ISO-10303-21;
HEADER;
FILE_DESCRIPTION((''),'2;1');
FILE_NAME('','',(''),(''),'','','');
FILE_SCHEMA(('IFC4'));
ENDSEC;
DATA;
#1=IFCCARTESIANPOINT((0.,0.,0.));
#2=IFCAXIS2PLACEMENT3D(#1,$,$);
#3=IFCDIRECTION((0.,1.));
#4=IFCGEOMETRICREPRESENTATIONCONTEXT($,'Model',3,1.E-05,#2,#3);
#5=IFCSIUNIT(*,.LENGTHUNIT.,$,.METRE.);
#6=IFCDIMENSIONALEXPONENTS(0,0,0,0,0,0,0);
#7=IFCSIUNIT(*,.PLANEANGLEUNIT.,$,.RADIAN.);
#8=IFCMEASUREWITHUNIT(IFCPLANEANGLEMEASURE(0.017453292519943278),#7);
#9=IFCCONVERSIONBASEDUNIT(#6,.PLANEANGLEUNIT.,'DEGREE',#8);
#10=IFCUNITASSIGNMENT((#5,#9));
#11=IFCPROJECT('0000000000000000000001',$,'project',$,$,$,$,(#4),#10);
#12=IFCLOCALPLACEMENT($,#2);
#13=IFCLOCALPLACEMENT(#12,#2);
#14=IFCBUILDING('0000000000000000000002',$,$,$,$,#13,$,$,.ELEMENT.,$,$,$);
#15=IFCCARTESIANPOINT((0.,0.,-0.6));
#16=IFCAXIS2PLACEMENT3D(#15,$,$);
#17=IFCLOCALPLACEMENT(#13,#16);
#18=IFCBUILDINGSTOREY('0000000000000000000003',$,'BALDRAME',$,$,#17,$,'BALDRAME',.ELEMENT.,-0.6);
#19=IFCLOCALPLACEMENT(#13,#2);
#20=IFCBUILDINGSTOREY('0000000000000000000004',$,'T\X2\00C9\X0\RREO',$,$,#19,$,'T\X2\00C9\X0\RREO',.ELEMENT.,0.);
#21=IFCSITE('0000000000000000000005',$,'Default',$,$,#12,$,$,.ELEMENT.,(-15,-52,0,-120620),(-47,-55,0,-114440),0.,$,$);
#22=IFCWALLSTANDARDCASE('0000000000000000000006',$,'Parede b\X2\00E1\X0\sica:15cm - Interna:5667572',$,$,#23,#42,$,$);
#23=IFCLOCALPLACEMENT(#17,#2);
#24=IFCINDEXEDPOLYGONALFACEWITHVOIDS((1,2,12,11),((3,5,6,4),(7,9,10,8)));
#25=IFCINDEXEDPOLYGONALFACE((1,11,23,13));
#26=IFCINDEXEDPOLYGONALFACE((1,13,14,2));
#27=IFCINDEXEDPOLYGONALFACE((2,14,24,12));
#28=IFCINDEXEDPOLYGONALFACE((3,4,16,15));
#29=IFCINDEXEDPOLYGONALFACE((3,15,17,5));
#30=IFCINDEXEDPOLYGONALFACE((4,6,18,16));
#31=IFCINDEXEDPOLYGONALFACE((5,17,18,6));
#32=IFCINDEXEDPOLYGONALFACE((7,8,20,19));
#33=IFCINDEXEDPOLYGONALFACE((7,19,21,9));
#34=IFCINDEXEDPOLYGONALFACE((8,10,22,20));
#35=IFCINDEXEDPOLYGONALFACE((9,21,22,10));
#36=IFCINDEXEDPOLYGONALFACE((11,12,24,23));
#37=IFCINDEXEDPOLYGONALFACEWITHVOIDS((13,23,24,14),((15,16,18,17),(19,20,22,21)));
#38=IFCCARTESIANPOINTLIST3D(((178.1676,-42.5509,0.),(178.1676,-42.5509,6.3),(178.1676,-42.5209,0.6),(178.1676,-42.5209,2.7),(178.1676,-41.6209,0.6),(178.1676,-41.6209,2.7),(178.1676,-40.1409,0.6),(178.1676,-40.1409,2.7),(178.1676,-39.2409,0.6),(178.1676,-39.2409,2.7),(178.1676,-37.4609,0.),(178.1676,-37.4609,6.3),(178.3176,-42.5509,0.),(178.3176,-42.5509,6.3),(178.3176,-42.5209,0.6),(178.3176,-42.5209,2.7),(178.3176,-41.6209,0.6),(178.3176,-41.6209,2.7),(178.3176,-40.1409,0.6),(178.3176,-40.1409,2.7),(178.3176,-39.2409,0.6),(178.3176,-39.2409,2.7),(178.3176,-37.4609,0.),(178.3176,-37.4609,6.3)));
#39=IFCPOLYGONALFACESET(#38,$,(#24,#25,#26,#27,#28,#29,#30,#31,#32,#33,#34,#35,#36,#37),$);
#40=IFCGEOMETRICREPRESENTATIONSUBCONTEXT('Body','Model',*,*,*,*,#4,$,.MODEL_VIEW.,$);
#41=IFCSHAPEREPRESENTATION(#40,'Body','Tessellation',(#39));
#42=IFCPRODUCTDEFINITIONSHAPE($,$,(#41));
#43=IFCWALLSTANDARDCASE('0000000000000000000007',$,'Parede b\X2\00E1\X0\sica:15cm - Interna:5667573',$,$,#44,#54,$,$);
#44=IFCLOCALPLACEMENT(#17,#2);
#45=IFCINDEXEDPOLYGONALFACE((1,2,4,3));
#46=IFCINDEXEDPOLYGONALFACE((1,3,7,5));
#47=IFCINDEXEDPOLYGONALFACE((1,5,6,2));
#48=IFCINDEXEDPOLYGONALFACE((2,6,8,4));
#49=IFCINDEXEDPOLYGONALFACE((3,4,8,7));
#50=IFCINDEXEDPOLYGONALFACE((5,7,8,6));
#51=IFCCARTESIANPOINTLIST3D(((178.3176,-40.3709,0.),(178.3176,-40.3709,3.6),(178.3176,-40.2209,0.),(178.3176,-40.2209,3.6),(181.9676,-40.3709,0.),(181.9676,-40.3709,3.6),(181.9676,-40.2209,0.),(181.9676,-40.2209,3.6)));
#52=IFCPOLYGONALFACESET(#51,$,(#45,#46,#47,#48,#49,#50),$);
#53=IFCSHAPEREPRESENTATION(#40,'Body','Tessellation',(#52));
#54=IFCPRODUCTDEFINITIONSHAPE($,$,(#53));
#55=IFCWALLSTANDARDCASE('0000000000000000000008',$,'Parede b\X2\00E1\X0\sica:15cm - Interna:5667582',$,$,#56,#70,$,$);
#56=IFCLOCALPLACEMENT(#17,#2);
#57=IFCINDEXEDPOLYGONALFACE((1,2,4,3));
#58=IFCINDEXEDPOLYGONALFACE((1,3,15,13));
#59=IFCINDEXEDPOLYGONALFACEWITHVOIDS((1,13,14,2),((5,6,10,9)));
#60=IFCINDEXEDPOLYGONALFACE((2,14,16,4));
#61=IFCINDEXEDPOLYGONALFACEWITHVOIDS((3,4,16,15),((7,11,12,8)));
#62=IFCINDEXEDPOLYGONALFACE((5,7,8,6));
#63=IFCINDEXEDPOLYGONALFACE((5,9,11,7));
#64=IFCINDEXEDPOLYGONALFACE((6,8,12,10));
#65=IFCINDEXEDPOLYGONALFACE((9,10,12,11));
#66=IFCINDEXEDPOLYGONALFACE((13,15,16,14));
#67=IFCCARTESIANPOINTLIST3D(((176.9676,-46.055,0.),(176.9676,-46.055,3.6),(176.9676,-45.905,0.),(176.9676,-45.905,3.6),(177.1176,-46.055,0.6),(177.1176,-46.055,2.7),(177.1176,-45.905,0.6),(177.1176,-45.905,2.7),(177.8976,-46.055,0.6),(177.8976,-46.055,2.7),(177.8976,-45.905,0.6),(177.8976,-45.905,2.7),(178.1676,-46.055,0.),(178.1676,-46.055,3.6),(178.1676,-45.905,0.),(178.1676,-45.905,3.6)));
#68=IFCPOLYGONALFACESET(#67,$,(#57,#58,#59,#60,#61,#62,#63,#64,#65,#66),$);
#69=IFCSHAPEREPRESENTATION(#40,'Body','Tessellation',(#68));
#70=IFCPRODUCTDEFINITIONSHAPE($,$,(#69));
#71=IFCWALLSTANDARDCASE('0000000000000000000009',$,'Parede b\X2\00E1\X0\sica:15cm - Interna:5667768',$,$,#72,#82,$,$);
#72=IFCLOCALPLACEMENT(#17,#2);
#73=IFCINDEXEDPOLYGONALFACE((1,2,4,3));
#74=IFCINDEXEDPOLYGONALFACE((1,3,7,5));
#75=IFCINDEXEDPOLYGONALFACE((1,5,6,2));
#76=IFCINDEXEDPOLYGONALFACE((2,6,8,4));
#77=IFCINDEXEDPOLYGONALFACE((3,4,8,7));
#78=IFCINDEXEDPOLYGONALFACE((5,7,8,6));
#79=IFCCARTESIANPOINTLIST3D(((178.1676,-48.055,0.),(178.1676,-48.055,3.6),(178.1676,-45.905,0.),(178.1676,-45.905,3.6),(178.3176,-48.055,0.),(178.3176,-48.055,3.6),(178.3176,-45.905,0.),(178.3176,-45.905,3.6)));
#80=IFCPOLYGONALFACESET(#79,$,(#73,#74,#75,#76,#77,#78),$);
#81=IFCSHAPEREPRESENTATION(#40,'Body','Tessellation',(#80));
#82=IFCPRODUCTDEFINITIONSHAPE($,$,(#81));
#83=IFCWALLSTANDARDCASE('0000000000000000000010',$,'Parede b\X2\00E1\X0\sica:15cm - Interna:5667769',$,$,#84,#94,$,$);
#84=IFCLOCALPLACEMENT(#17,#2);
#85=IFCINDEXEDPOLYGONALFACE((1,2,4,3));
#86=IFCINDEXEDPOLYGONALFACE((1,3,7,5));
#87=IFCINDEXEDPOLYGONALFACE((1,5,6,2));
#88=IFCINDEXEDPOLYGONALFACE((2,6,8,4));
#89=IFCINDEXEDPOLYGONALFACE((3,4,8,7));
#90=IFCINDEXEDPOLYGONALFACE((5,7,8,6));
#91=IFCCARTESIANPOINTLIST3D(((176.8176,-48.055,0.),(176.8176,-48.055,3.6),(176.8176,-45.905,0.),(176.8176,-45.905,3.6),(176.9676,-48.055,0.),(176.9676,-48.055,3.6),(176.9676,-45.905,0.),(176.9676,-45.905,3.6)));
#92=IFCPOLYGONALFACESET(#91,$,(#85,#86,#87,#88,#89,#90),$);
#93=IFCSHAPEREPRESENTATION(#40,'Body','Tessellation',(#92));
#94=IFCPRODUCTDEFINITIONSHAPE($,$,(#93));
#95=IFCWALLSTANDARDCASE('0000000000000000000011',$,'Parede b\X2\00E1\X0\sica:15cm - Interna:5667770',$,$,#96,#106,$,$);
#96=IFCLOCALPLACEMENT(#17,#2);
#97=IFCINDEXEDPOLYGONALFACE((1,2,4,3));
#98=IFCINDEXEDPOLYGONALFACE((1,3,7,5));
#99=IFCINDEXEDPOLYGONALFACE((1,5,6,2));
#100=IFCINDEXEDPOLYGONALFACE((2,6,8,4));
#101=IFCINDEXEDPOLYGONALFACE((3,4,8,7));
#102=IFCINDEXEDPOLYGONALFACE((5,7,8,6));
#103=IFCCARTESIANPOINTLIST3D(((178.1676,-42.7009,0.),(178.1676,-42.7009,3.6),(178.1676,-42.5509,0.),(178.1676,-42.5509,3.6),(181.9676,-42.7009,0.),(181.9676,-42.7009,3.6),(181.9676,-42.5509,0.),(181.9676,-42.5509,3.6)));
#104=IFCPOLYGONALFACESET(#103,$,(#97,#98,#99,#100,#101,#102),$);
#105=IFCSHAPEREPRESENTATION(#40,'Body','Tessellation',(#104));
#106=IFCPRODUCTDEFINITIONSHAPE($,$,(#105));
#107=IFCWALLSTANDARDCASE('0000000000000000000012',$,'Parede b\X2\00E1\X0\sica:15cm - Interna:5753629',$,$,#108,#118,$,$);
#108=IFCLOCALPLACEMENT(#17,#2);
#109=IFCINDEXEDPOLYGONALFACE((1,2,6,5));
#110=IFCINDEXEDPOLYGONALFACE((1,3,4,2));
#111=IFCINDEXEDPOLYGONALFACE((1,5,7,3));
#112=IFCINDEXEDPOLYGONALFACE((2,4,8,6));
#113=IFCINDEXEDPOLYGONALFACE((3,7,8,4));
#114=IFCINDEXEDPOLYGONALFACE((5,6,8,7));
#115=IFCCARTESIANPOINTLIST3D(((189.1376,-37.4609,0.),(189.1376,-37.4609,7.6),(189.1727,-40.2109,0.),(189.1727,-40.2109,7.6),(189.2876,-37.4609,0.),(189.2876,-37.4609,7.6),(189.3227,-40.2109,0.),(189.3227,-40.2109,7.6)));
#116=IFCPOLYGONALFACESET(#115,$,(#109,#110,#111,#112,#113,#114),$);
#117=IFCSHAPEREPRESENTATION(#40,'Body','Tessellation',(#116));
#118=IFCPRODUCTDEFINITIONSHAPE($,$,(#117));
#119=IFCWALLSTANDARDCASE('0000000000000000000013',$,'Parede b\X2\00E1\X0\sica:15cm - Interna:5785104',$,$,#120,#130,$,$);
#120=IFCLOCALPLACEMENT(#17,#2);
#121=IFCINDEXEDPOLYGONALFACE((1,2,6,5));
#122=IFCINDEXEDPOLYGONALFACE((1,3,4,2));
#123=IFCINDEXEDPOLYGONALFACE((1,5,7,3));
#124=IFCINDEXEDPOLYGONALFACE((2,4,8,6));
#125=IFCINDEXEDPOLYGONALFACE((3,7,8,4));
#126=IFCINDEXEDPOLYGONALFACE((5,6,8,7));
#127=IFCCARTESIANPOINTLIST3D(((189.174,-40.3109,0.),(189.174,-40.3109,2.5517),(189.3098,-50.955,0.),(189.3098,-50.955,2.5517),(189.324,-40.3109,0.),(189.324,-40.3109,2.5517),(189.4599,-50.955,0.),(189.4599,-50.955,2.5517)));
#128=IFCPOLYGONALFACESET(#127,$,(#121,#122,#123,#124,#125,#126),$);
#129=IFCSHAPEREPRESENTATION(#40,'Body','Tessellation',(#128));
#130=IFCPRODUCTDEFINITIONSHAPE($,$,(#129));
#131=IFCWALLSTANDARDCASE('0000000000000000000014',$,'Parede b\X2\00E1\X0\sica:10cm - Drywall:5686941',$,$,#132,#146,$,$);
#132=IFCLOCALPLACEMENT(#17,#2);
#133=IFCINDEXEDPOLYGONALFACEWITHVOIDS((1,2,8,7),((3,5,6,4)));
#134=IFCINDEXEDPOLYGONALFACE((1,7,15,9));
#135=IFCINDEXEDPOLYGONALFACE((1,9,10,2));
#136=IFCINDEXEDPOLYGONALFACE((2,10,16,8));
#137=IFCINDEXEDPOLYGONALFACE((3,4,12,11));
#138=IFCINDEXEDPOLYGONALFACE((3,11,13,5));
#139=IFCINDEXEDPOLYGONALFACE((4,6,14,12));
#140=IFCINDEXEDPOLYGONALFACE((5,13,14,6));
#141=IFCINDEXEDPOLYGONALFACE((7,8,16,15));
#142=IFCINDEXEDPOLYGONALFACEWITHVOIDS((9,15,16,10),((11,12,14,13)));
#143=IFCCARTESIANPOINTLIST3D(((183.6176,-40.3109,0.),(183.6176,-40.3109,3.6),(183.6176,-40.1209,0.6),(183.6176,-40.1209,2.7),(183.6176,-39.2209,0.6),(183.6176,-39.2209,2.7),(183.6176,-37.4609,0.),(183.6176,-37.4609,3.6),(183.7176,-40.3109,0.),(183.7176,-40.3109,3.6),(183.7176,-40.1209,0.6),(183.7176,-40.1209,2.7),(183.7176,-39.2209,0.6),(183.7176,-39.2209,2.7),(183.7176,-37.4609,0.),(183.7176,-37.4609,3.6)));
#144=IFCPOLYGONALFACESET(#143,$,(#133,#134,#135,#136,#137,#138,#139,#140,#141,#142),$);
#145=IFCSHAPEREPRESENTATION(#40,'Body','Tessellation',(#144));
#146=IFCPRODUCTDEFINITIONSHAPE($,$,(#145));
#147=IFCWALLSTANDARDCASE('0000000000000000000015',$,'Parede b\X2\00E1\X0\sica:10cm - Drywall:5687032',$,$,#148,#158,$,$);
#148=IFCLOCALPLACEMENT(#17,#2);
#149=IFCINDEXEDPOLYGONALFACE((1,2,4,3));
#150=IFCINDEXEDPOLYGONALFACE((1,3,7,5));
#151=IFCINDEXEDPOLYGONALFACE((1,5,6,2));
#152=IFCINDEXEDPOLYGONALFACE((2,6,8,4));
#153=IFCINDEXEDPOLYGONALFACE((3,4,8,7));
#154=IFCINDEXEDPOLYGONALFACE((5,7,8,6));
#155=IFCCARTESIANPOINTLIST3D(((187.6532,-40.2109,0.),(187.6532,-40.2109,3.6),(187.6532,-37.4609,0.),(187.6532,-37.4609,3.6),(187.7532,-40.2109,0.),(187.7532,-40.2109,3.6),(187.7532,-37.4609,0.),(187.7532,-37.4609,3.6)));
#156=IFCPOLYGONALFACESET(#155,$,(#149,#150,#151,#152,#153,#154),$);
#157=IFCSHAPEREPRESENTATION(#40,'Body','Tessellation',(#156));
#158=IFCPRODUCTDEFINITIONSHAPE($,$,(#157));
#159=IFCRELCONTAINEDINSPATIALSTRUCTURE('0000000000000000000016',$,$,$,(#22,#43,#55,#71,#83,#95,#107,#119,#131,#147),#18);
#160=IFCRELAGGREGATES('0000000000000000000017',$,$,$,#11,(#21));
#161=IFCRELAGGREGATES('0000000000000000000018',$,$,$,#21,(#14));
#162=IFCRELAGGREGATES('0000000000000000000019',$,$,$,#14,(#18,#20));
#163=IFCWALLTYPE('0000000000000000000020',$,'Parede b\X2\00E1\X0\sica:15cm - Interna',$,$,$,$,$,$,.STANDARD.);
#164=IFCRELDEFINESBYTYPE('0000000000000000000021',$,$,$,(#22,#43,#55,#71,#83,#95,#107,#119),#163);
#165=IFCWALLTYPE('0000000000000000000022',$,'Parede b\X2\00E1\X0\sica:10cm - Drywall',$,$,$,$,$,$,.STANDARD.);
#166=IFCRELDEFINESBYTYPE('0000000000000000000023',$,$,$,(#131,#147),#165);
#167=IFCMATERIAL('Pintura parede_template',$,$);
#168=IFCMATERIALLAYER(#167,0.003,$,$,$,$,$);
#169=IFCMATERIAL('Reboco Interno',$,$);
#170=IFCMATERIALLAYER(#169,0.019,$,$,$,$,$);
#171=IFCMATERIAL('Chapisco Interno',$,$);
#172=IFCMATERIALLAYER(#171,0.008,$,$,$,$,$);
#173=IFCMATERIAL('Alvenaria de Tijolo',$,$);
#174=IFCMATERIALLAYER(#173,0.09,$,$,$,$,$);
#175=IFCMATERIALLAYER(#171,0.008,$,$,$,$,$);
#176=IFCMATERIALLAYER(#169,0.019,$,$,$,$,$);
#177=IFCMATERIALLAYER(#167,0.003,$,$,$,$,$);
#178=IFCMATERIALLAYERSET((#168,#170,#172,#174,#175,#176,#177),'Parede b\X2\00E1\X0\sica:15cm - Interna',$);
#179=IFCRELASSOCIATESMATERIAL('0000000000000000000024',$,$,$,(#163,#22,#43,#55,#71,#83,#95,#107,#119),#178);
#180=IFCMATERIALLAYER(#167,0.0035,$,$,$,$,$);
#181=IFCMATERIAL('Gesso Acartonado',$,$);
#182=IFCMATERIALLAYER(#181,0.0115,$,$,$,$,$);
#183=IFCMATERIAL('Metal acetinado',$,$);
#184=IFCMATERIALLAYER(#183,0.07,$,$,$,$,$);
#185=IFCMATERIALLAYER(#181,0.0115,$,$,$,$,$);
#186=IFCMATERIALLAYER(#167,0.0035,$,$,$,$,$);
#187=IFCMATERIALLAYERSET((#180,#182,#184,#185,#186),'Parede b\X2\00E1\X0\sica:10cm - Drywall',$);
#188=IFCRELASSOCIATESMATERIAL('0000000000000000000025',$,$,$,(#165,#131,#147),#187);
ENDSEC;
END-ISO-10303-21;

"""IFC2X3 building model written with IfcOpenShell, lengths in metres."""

from ifc_helpers import new_model, entity, si_unit, converted_unit, direction, frame, frame_2d, origin, place, context, subcontext, project, spatial, polyline, rectangle, outline, extrude, material, layer, layer_set, layer_usage, type_object, element, save


model = new_model("IFC2X3")

# Units and contexts
model_context = context("Model", 3, precision=1e-05, world=origin(), true_north=direction((0.0, 1.0)))
body_context = subcontext(model_context, "Body", "Model", "MODEL_VIEW")
ifc_project = project(units=[si_unit("LENGTHUNIT", "METRE"), converted_unit("PLANEANGLEUNIT", "DEGREE", entity("IfcPlaneAngleMeasure", 0.017453292519943278), si_unit("PLANEANGLEUNIT", "RADIAN"), dimensions=[0, 0, 0, 0, 0, 0, 0])], contexts=[model_context])

# Site, building, storey
site_placement = place(None, origin())
site = spatial("IfcSite", under=ifc_project, at=site_placement, Name="Default", CompositionType="ELEMENT", RefLatitude=(-15, -52, 0, -120620), RefLongitude=(-47, -55, 0, -114440), RefElevation=0.0)
building_placement = place(site_placement, origin())
building = spatial("IfcBuilding", under=site, at=building_placement, CompositionType="ELEMENT")
storey_1_placement = place(building_placement, frame((0.0, 0.0, -0.6)))
storey_1 = spatial("IfcBuildingStorey", under=building, at=storey_1_placement, Name="BALDRAME", LongName="BALDRAME", CompositionType="ELEMENT", Elevation=-0.6)

# Shared definitions
ifc_material_1 = material(Name="Pintura parede_template")
ifc_layer_1 = layer(ifc_material_1, 0.003)
ifc_material_2 = material(Name="Reboco Interno")
ifc_layer_2 = layer(ifc_material_2, 0.019)
ifc_material_3 = material(Name="Chapisco Interno")
ifc_layer_3 = layer(ifc_material_3, 0.008)
ifc_material_4 = material(Name="Alvenaria de Tijolo")
ifc_layer_4 = layer(ifc_material_4, 0.09)
ifc_layer_5 = layer(ifc_material_3, 0.008)
ifc_layer_6 = layer(ifc_material_2, 0.019)
ifc_layer_7 = layer(ifc_material_1, 0.003)
ifc_layer_set_1 = layer_set([ifc_layer_1, ifc_layer_2, ifc_layer_3, ifc_layer_4, ifc_layer_5, ifc_layer_6, ifc_layer_7], Name="Parede básica:15cm - Interna")
wall_type_1 = type_object("IfcWallType", Name="Parede básica:15cm - Interna", PredefinedType="STANDARD", material=ifc_layer_set_1)

# Shared definitions
storey_2_placement = place(building_placement, origin())
storey_2 = spatial("IfcBuildingStorey", under=building, at=storey_2_placement, Name="TÉRREO", LongName="TÉRREO", CompositionType="ELEMENT", Elevation=0.0)

# Shared definitions
ifc_material_5 = material(Name="Metal acetinado")

# Wall, openings
ifc_layer_usage_1 = layer_usage(ifc_layer_set_1, "AXIS2", "POSITIVE", -0.075)
wall_1_placement = place(storey_1_placement, frame((178.2426, -37.4609, 0.0), z_axis=(0.0, 0.0, 1.0), x_axis=(0.0, -1.0, 0.0)))
wall_1 = element("IfcWallStandardCase", 1, at=wall_1_placement, inside=storey_1, type_object=wall_type_1, material=ifc_layer_usage_1, Name="Parede básica:15cm - Interna:5667572", context=body_context, shape_type="SweptSolid", body=[
    extrude(rectangle(XDim=5.09, YDim=0.15, at=frame_2d((2.545, 0.0), x_axis=(-1.0, 0.0))), origin(), (0.0, 0.0, 1.0), 6.3),
])
opening_1_placement = place(wall_1_placement, frame((4.16, -0.075, 0.6)))
element("IfcOpeningElement", 2, at=opening_1_placement, cuts=wall_1, ObjectType="Opening", context=body_context, shape_type="SweptSolid", body=[
    extrude(rectangle(XDim=0.9, YDim=2.1, at=frame_2d((1.05, 0.45), x_axis=(0.0, 1.0))), frame((0.0, 0.0, 0.0), z_axis=(0.0, 1.0, 0.0), x_axis=(0.0, 0.0, 1.0)), (0.0, 0.0, 1.0), 0.15),
])
opening_2_placement = place(wall_1_placement, frame((1.78, -0.075, 0.6)))
element("IfcOpeningElement", 3, at=opening_2_placement, cuts=wall_1, ObjectType="Opening", context=body_context, shape_type="SweptSolid", body=[
    extrude(rectangle(XDim=0.9, YDim=2.1, at=frame_2d((1.05, 0.45), x_axis=(0.0, 1.0))), frame((0.0, 0.0, 0.0), z_axis=(0.0, 1.0, 0.0), x_axis=(0.0, 0.0, 1.0)), (0.0, 0.0, 1.0), 0.15),
])

# Wall
ifc_layer_usage_2 = layer_usage(ifc_layer_set_1, "AXIS2", "NEGATIVE", 0.075)
wall_2_placement = place(storey_1_placement, frame((178.3176, -40.2959, 0.0)))
element("IfcWallStandardCase", 4, at=wall_2_placement, inside=storey_1, type_object=wall_type_1, material=ifc_layer_usage_2, Name="Parede básica:15cm - Interna:5667573", context=body_context, shape_type="SweptSolid", body=[
    extrude(rectangle(XDim=3.65, YDim=0.15, at=frame_2d((1.825, 0.0), x_axis=(-1.0, 0.0))), origin(), (0.0, 0.0, 1.0), 3.6),
])

# Wall, opening
ifc_layer_usage_3 = layer_usage(ifc_layer_set_1, "AXIS2", "NEGATIVE", 0.075)
wall_3_placement = place(storey_1_placement, frame((178.1676, -45.98, 0.0), z_axis=(0.0, 0.0, 1.0), x_axis=(-1.0, 0.0, 0.0)))
wall_3 = element("IfcWallStandardCase", 5, at=wall_3_placement, inside=storey_1, type_object=wall_type_1, material=ifc_layer_usage_3, Name="Parede básica:15cm - Interna:5667582", context=body_context, shape_type="SweptSolid", body=[
    extrude(rectangle(XDim=1.2, YDim=0.15, at=frame_2d((0.6, 0.0), x_axis=(-1.0, 0.0))), origin(), (0.0, 0.0, 1.0), 3.6),
])
opening_3_placement = place(wall_3_placement, frame((0.27, -0.075, 0.6)))
element("IfcOpeningElement", 6, at=opening_3_placement, cuts=wall_3, ObjectType="Opening", context=body_context, shape_type="SweptSolid", body=[
    extrude(rectangle(XDim=0.78, YDim=2.1, at=frame_2d((1.05, 0.39), x_axis=(0.0, 1.0))), frame((0.0, 0.0, 0.0), z_axis=(0.0, 1.0, 0.0), x_axis=(0.0, 0.0, 1.0)), (0.0, 0.0, 1.0), 0.15),
])

# Walls
ifc_layer_usage_4 = layer_usage(ifc_layer_set_1, "AXIS2", "POSITIVE", -0.075)
wall_4_placement = place(storey_1_placement, frame((178.2426, -45.905, 0.0), z_axis=(0.0, 0.0, 1.0), x_axis=(0.0, -1.0, 0.0)))
element("IfcWallStandardCase", 7, at=wall_4_placement, inside=storey_1, type_object=wall_type_1, material=ifc_layer_usage_4, Name="Parede básica:15cm - Interna:5667768", context=body_context, shape_type="SweptSolid", body=[
    extrude(rectangle(XDim=2.15, YDim=0.15, at=frame_2d((1.075, 0.0), x_axis=(-1.0, 0.0))), origin(), (0.0, 0.0, 1.0), 3.6),
])
ifc_layer_usage_5 = layer_usage(ifc_layer_set_1, "AXIS2", "NEGATIVE", 0.075)
wall_5_placement = place(storey_1_placement, frame((176.8926, -45.905, 0.0), z_axis=(0.0, 0.0, 1.0), x_axis=(0.0, -1.0, 0.0)))
element("IfcWallStandardCase", 8, at=wall_5_placement, inside=storey_1, type_object=wall_type_1, material=ifc_layer_usage_5, Name="Parede básica:15cm - Interna:5667769", context=body_context, shape_type="SweptSolid", body=[
    extrude(rectangle(XDim=2.15, YDim=0.15, at=frame_2d((1.075, 0.0), x_axis=(-1.0, 0.0))), origin(), (0.0, 0.0, 1.0), 3.6),
])
ifc_layer_usage_6 = layer_usage(ifc_layer_set_1, "AXIS2", "NEGATIVE", 0.075)
wall_6_placement = place(storey_1_placement, frame((178.1676, -42.6259, 0.0)))
element("IfcWallStandardCase", 9, at=wall_6_placement, inside=storey_1, type_object=wall_type_1, material=ifc_layer_usage_6, Name="Parede básica:15cm - Interna:5667770", context=body_context, shape_type="SweptSolid", body=[
    extrude(rectangle(XDim=3.8, YDim=0.15, at=frame_2d((1.9, 0.0), x_axis=(-1.0, 0.0))), origin(), (0.0, 0.0, 1.0), 3.6),
])
ifc_layer_usage_7 = layer_usage(ifc_layer_set_1, "AXIS2", "NEGATIVE", 0.075)
wall_7_placement = place(storey_1_placement, frame((189.2126, -37.4599, 0.0), z_axis=(0.0, 0.0, 1.0), x_axis=(0.012766, -0.999919, 0.0)))
element("IfcWallStandardCase", 10, at=wall_7_placement, inside=storey_1, type_object=wall_type_1, material=ifc_layer_usage_7, Name="Parede básica:15cm - Interna:5753629", context=body_context, shape_type="SweptSolid", body=[
    extrude(outline(polyline([(2.7502, -0.075), (2.7521, 0.075), (0.0019, 0.075), (0.0, -0.075), (2.7502, -0.075)])), origin(), (0.0, 0.0, 1.0), 7.6),
])
ifc_layer_usage_8 = layer_usage(ifc_layer_set_1, "AXIS2", "NEGATIVE", 0.075)
wall_8_placement = place(storey_1_placement, frame((189.2489, -40.3099, 0.0), z_axis=(0.0, 0.0, 1.0), x_axis=(0.012766, -0.999919, 0.0)))
element("IfcWallStandardCase", 11, at=wall_8_placement, inside=storey_1, type_object=wall_type_1, material=ifc_layer_usage_8, Name="Parede básica:15cm - Interna:5785104", context=body_context, shape_type="SweptSolid", body=[
    extrude(outline(polyline([(10.645, -0.075), (10.6469, 0.075), (0.0019, 0.075), (0.0, -0.075), (10.645, -0.075)])), origin(), (0.0, 0.0, 1.0), 2.5517),
])

# Wall, opening
ifc_layer_8 = layer(ifc_material_1, 0.0035)
ifc_material_6 = material(Name="Gesso Acartonado")
ifc_layer_9 = layer(ifc_material_6, 0.0115)
ifc_layer_10 = layer(ifc_material_5, 0.07)
ifc_layer_11 = layer(ifc_material_6, 0.0115)
ifc_layer_12 = layer(ifc_material_1, 0.0035)
ifc_layer_set_2 = layer_set([ifc_layer_8, ifc_layer_9, ifc_layer_10, ifc_layer_11, ifc_layer_12], Name="Parede básica:10cm - Drywall")
ifc_layer_usage_9 = layer_usage(ifc_layer_set_2, "AXIS2", "NEGATIVE", 0.05)
wall_type_2 = type_object("IfcWallType", Name="Parede básica:10cm - Drywall", PredefinedType="STANDARD", material=ifc_layer_set_2)
wall_9_placement = place(storey_1_placement, frame((183.6676, -37.4609, 0.0), z_axis=(0.0, 0.0, 1.0), x_axis=(0.0, -1.0, 0.0)))
wall_9 = element("IfcWallStandardCase", 12, at=wall_9_placement, inside=storey_1, type_object=wall_type_2, material=ifc_layer_usage_9, Name="Parede básica:10cm - Drywall:5686941", context=body_context, shape_type="SweptSolid", body=[
    extrude(rectangle(XDim=2.85, YDim=0.1, at=frame_2d((1.425, 0.0), x_axis=(-1.0, 0.0))), origin(), (0.0, 0.0, 1.0), 3.6),
])
opening_4_placement = place(wall_9_placement, frame((1.76, -0.05, 0.6)))
element("IfcOpeningElement", 13, at=opening_4_placement, cuts=wall_9, ObjectType="Opening", context=body_context, shape_type="SweptSolid", body=[
    extrude(rectangle(XDim=0.9, YDim=2.1, at=frame_2d((1.05, 0.45), x_axis=(0.0, 1.0))), frame((0.0, 0.0, 0.0), z_axis=(0.0, 1.0, 0.0), x_axis=(0.0, 0.0, 1.0)), (0.0, 0.0, 1.0), 0.1),
])

# Wall
ifc_layer_usage_10 = layer_usage(ifc_layer_set_2, "AXIS2", "NEGATIVE", 0.05)
wall_10_placement = place(storey_1_placement, frame((187.7032, -40.2109, 0.0), z_axis=(0.0, 0.0, 1.0), x_axis=(0.0, 1.0, 0.0)))
element("IfcWallStandardCase", 14, at=wall_10_placement, inside=storey_1, type_object=wall_type_2, material=ifc_layer_usage_10, Name="Parede básica:10cm - Drywall:5687032", context=body_context, shape_type="SweptSolid", body=[
    extrude(rectangle(XDim=2.75, YDim=0.1, at=frame_2d((1.375, 0.0), x_axis=(-1.0, 0.0))), origin(), (0.0, 0.0, 1.0), 3.6),
])

save(model, "model.ifc")
